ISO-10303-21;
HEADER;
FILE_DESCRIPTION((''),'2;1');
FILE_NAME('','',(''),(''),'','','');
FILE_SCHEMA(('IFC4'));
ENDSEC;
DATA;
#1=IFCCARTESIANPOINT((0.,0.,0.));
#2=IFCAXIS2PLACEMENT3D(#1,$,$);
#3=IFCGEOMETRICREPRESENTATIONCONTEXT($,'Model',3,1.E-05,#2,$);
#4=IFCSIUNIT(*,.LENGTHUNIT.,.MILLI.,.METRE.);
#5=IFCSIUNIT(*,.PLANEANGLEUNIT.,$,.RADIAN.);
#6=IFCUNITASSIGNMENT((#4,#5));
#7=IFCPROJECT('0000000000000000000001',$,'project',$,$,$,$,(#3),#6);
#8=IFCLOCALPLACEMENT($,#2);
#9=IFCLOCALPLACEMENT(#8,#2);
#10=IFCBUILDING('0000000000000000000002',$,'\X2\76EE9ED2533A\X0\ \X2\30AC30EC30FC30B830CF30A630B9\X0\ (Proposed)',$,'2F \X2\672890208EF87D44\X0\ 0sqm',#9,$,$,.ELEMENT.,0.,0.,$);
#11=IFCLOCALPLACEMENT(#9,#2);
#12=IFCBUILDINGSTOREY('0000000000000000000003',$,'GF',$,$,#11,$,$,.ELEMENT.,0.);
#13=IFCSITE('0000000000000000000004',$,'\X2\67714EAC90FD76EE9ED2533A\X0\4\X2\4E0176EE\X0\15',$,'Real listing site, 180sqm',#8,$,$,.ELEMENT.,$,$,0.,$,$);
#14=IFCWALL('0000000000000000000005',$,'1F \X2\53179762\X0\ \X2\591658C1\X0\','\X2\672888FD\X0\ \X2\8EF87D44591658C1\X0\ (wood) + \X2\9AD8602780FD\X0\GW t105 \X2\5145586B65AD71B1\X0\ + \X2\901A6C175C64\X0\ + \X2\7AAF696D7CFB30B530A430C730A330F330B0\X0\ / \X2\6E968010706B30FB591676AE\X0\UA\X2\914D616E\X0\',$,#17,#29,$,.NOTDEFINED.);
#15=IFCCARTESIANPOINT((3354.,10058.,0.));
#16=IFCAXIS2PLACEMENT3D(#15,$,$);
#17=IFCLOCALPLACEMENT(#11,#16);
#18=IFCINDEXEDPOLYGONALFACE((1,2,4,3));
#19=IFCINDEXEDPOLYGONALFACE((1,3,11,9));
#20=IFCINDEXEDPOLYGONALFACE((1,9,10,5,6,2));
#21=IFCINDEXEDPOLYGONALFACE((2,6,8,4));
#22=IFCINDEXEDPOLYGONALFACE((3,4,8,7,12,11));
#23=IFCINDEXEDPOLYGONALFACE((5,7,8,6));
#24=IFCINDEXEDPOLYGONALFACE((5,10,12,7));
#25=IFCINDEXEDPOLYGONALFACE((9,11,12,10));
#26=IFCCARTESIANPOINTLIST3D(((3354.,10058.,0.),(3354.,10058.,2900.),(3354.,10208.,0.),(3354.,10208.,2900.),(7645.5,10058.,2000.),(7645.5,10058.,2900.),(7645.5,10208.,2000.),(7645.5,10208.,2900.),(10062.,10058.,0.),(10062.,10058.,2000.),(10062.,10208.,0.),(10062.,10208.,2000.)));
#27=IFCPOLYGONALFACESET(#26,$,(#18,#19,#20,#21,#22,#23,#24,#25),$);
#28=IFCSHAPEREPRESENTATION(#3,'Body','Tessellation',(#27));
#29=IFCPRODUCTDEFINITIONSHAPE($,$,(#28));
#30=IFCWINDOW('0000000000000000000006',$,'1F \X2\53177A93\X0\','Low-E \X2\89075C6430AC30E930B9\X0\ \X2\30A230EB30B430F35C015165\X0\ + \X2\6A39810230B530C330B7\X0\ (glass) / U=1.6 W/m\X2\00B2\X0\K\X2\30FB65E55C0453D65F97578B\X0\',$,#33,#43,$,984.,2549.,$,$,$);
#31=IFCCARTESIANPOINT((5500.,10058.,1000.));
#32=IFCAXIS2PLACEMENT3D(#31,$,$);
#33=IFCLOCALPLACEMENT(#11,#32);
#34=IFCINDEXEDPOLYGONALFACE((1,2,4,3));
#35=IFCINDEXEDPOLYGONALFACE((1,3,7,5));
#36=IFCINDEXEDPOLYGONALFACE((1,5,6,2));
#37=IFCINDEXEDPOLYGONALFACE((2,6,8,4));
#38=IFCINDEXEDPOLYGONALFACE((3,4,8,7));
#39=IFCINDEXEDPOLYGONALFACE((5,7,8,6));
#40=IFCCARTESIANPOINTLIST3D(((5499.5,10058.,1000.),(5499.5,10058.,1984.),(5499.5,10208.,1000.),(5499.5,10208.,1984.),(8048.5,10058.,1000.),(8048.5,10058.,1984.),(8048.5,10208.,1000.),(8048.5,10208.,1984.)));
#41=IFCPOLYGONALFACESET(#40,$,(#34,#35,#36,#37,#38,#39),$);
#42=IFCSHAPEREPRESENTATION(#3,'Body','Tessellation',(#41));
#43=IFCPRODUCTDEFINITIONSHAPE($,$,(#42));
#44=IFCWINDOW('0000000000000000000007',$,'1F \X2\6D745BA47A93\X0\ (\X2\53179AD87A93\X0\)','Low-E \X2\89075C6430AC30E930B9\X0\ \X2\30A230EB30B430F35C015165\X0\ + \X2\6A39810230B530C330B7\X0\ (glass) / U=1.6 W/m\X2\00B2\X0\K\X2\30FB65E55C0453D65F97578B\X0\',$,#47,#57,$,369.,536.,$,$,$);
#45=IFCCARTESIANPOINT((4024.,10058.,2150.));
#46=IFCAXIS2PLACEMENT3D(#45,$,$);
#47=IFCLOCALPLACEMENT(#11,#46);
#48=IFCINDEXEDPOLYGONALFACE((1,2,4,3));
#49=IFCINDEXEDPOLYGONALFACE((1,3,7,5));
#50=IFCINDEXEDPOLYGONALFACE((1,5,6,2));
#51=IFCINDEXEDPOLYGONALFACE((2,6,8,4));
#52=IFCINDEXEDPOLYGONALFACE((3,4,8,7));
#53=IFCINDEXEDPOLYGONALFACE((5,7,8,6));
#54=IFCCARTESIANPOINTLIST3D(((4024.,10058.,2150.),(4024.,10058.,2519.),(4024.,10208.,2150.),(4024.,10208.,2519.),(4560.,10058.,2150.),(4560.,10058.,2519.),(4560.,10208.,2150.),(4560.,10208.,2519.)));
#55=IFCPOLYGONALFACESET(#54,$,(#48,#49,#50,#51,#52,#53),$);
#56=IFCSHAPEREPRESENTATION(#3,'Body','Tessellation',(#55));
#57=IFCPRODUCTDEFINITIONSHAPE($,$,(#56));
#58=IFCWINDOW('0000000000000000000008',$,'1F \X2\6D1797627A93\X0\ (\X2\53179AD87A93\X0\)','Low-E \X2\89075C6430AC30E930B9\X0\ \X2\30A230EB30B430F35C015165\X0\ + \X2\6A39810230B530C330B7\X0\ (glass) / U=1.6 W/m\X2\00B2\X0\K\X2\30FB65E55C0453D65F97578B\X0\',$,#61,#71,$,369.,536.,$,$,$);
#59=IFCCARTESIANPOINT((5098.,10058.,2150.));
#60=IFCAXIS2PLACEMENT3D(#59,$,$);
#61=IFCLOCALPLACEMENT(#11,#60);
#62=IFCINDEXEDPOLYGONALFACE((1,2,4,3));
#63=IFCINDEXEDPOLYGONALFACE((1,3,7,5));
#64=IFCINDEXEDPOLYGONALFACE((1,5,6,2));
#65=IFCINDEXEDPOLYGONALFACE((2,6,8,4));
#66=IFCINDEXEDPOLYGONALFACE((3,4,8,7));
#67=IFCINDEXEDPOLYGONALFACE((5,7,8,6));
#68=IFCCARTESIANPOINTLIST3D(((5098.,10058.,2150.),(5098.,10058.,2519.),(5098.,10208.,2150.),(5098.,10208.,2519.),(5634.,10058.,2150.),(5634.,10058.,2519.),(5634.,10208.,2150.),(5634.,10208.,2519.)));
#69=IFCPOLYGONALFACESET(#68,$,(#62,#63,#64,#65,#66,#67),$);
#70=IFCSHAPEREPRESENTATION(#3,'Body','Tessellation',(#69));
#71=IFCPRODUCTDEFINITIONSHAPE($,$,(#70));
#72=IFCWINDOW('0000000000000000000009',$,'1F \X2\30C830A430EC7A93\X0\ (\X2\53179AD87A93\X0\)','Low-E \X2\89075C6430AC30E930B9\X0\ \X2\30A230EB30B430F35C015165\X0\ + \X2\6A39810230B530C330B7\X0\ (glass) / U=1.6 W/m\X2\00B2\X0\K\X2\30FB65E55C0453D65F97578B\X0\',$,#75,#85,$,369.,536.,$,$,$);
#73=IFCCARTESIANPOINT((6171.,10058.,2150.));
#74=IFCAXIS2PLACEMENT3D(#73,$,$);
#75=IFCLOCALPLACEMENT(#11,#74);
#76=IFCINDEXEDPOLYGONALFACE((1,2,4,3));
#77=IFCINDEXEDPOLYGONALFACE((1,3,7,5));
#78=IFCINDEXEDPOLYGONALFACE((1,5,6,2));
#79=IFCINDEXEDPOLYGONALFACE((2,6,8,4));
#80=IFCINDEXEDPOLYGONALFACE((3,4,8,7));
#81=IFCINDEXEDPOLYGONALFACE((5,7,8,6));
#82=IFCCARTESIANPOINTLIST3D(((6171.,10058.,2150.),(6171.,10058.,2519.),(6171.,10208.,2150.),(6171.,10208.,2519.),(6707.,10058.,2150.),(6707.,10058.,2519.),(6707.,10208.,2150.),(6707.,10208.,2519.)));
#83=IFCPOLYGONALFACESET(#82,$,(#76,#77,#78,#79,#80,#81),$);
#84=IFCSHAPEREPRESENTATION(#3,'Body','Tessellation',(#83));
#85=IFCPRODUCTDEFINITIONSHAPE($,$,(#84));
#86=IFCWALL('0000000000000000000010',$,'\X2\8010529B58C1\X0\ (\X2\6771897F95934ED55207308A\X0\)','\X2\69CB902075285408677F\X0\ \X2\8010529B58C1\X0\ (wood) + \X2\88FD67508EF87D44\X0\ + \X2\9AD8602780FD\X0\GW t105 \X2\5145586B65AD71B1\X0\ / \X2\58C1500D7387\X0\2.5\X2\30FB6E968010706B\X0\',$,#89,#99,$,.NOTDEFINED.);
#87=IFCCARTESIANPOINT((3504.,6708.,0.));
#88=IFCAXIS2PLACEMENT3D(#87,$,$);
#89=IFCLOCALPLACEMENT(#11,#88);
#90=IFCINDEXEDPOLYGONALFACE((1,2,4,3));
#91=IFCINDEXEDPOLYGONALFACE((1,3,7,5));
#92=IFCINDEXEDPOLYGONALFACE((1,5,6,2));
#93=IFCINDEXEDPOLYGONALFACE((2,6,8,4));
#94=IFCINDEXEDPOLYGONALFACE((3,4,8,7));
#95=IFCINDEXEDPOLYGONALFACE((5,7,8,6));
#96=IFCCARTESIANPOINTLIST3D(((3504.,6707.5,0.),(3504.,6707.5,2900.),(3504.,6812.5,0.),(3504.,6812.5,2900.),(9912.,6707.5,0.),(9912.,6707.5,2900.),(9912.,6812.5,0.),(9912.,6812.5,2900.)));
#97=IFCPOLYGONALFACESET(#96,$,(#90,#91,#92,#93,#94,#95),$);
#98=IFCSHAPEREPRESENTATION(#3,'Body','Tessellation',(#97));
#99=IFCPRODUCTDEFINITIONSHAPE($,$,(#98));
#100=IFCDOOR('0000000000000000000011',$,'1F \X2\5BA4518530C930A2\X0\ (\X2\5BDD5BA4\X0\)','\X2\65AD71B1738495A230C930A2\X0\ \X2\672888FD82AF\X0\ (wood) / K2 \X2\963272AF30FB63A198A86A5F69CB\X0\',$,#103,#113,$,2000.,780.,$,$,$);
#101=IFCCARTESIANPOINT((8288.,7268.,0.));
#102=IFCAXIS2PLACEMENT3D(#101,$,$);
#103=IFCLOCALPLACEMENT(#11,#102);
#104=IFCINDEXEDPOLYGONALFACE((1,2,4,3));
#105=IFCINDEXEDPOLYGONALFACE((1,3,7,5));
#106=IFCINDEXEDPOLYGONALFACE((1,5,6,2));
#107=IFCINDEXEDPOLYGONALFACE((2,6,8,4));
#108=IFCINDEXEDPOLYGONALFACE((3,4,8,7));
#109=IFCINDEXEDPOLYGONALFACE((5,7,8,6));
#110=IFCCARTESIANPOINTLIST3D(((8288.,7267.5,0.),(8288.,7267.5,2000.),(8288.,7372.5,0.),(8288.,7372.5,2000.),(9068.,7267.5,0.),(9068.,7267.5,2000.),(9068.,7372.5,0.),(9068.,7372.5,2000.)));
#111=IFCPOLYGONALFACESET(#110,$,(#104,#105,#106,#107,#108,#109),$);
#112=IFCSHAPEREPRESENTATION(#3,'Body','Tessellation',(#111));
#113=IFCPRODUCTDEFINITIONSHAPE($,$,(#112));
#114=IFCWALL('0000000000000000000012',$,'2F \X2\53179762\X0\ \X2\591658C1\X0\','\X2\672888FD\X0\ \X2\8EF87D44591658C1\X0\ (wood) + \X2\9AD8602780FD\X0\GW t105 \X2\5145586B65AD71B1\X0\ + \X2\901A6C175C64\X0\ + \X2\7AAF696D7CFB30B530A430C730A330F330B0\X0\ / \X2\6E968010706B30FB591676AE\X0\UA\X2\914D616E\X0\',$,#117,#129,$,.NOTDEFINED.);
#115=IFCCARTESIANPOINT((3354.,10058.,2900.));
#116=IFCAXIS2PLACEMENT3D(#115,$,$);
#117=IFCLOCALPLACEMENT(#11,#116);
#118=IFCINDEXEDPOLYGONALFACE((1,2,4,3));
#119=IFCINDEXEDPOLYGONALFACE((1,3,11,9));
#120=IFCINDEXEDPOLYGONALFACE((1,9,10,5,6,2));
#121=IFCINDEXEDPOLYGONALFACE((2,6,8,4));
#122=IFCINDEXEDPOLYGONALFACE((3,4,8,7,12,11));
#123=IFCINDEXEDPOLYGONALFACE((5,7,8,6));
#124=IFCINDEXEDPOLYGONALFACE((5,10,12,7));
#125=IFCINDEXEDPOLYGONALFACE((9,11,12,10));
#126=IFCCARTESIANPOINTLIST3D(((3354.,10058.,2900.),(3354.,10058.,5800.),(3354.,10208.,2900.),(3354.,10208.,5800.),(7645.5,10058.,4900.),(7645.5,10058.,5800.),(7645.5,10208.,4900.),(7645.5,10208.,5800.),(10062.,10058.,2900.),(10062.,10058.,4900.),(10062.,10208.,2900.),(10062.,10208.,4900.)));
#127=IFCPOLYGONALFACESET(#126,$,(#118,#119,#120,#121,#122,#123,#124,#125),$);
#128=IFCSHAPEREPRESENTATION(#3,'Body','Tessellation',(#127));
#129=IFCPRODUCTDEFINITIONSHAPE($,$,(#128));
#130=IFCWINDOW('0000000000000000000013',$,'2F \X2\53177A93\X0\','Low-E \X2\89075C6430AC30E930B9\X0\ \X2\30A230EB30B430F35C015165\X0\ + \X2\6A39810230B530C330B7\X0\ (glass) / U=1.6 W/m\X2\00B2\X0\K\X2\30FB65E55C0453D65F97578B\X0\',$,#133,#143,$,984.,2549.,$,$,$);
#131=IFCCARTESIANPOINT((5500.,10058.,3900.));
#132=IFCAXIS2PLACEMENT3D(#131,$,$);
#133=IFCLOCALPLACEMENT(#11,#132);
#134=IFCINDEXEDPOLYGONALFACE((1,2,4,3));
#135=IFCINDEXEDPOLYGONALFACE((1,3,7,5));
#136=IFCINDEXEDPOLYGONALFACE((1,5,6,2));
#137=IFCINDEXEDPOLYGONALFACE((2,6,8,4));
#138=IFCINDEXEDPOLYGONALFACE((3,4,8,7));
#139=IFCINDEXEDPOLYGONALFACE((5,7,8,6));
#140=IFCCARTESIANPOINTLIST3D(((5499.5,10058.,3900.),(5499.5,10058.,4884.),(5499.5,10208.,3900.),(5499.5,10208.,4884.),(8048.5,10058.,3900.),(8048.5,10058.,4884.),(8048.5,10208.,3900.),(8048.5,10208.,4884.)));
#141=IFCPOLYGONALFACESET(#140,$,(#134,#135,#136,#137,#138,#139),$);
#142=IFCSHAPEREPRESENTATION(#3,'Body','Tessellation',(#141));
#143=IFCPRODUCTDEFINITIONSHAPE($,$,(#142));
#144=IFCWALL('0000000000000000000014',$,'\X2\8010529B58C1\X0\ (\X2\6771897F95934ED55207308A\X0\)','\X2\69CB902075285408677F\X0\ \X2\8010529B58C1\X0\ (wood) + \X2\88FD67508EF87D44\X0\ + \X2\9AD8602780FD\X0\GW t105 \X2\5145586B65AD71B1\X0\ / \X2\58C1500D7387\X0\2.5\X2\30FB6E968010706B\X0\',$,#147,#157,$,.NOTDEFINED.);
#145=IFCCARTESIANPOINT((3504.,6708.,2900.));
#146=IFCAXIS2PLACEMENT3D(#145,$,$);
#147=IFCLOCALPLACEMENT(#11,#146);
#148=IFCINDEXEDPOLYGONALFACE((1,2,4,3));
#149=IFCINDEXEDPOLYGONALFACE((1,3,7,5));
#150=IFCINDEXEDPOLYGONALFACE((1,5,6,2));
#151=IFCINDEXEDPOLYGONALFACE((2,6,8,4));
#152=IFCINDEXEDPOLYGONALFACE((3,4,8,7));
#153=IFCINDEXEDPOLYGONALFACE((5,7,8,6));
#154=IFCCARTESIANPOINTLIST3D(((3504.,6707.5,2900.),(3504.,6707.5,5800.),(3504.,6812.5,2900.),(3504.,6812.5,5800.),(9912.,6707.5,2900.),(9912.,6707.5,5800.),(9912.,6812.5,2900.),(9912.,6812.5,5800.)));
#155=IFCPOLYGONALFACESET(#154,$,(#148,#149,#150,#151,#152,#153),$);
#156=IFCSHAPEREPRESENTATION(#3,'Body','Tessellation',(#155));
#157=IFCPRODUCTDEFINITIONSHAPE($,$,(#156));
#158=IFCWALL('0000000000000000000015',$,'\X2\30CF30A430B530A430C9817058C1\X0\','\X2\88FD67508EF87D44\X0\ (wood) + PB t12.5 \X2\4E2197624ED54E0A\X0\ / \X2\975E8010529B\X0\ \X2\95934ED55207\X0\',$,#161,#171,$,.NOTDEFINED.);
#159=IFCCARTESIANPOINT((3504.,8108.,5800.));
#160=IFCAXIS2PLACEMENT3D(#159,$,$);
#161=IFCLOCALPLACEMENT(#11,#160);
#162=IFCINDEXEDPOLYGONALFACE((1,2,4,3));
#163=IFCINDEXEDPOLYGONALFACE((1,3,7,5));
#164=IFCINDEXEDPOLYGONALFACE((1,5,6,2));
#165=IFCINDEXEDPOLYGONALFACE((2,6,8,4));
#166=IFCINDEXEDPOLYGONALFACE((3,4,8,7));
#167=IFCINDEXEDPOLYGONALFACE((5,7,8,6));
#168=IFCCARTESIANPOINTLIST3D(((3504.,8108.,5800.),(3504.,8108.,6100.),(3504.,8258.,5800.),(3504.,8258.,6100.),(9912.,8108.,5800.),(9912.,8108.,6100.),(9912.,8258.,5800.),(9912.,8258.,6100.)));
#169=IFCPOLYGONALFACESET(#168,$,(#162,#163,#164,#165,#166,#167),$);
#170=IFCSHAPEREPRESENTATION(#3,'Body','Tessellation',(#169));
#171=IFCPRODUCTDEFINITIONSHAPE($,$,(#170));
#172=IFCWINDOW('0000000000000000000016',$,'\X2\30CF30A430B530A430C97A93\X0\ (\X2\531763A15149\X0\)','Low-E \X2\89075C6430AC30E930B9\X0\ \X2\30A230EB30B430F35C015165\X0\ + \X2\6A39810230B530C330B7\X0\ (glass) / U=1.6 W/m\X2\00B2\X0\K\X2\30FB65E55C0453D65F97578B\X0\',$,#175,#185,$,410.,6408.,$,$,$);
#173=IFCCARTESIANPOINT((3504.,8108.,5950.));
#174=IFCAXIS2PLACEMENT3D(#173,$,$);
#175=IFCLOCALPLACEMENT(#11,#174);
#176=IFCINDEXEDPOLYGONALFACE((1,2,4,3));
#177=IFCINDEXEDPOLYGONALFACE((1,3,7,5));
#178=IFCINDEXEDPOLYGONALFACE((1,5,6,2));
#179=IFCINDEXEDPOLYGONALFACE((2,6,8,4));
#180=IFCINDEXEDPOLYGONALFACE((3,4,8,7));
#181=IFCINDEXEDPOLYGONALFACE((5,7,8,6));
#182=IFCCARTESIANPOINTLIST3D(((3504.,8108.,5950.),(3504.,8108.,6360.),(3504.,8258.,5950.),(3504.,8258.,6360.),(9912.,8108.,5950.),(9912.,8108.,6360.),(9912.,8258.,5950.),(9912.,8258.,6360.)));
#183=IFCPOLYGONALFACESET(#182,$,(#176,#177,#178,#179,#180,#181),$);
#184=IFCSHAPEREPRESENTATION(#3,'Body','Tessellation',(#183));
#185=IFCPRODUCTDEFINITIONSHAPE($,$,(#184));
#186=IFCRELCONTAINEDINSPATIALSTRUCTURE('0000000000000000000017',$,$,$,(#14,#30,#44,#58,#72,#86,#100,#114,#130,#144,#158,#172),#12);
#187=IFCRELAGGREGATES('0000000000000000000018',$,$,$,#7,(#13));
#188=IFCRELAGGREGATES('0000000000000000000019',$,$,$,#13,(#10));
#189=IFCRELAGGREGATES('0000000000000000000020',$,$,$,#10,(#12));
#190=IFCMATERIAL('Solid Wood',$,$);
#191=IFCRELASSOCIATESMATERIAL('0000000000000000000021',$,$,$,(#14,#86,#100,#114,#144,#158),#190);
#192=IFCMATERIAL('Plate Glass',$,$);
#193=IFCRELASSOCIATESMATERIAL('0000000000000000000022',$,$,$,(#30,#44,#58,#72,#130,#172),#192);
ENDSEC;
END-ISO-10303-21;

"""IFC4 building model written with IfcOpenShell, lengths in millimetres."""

from ifc_helpers import new_model, si_unit, frame, frame_2d, origin, place, context, project, spatial, rectangle, extrude, material, element, fill, save


model = new_model("IFC4")

# Units and contexts
model_context = context("Model", 3, precision=1e-05, world=origin())
ifc_project = project(units=[si_unit("LENGTHUNIT", "METRE", prefix="MILLI"), si_unit("PLANEANGLEUNIT", "RADIAN")], contexts=[model_context])

# Site, building, storey
site_placement = place(None, origin())
site = spatial("IfcSite", under=ifc_project, at=site_placement, Name="東京都目黒区4丁目15", ObjectType="Real listing site, 180sqm", CompositionType="ELEMENT", RefElevation=0.0)
building_placement = place(site_placement, origin())
building = spatial("IfcBuilding", under=site, at=building_placement, Name="目黒区 ガレージハウス (Proposed)", ObjectType="2F 木造軸組 0sqm", CompositionType="ELEMENT", ElevationOfRefHeight=0.0, ElevationOfTerrain=0.0)
storey_placement = place(building_placement, origin())
storey = spatial("IfcBuildingStorey", under=building, at=storey_placement, Name="GF", CompositionType="ELEMENT", Elevation=0.0)

# Wall, openings, windows
ifc_material_1 = material(Name="Solid Wood")
wall_1_placement = place(storey_placement, frame((3354.0, 10058.0, 0.0)))
wall_1 = element("IfcWall", 1, at=wall_1_placement, inside=storey, material=ifc_material_1, Name="1F 北面 外壁", Description="木製 軸組外壁 (wood) + 高性能GW t105 充填断熱 + 通気層 + 窯業系サイディング / 準耐火・外皮UA配慮", PredefinedType="NOTDEFINED", context=model_context, shape_type="SweptSolid", body=[
    extrude(rectangle(XDim=6708.0, YDim=150.0, at=frame_2d((3354.0, 75.0))), frame((3354.0, 10058.0, 0.0)), (0.0, 0.0, 1.0), 2900.0),
])
opening_1_placement = place(storey_placement, frame((5500.0, 10058.0, 1000.0)))
opening_1 = element("IfcOpeningElement", 2, at=opening_1_placement, cuts=wall_1, PredefinedType="NOTDEFINED", context=model_context, shape_type="SweptSolid", body=[
    extrude(rectangle(XDim=2549.0, YDim=150.0, at=frame_2d((1274.0, 75.0))), frame((5500.0, 10058.0, 1000.0)), (0.0, 0.0, 1.0), 984.0),
])
opening_2_placement = place(storey_placement, frame((4024.0, 10058.0, 2150.0)))
opening_2 = element("IfcOpeningElement", 3, at=opening_2_placement, cuts=wall_1, PredefinedType="NOTDEFINED", context=model_context, shape_type="SweptSolid", body=[
    extrude(rectangle(XDim=536.0, YDim=150.0, at=frame_2d((268.0, 75.0))), frame((4024.0, 10058.0, 2150.0)), (0.0, 0.0, 1.0), 369.0),
])
opening_3_placement = place(storey_placement, frame((5098.0, 10058.0, 2150.0)))
opening_3 = element("IfcOpeningElement", 4, at=opening_3_placement, cuts=wall_1, PredefinedType="NOTDEFINED", context=model_context, shape_type="SweptSolid", body=[
    extrude(rectangle(XDim=536.0, YDim=150.0, at=frame_2d((268.0, 75.0))), frame((5098.0, 10058.0, 2150.0)), (0.0, 0.0, 1.0), 369.0),
])
opening_4_placement = place(storey_placement, frame((6171.0, 10058.0, 2150.0)))
opening_4 = element("IfcOpeningElement", 5, at=opening_4_placement, cuts=wall_1, PredefinedType="NOTDEFINED", context=model_context, shape_type="SweptSolid", body=[
    extrude(rectangle(XDim=536.0, YDim=150.0, at=frame_2d((268.0, 75.0))), frame((6171.0, 10058.0, 2150.0)), (0.0, 0.0, 1.0), 369.0),
])
ifc_material_2 = material(Name="Plate Glass")
window_1_placement = place(storey_placement, frame((5500.0, 10058.0, 1000.0)))
window_1 = element("IfcWindow", 6, at=window_1_placement, inside=storey, material=ifc_material_2, Name="1F 北窓", Description="Low-E 複層ガラス アルゴン封入 + 樹脂サッシ (glass) / U=1.6 W/m²K・日射取得型", OverallHeight=984.0, OverallWidth=2549.0, context=model_context, shape_type="SweptSolid", body=[
    extrude(rectangle(XDim=2549.0, YDim=150.0, at=frame_2d((1274.0, 75.0))), frame((5500.0, 10058.0, 1000.0)), (0.0, 0.0, 1.0), 984.0),
])
fill(opening_1, window_1)
window_2_placement = place(storey_placement, frame((4024.0, 10058.0, 2150.0)))
window_2 = element("IfcWindow", 7, at=window_2_placement, inside=storey, material=ifc_material_2, Name="1F 浴室窓 (北高窓)", Description="Low-E 複層ガラス アルゴン封入 + 樹脂サッシ (glass) / U=1.6 W/m²K・日射取得型", OverallHeight=369.0, OverallWidth=536.0, context=model_context, shape_type="SweptSolid", body=[
    extrude(rectangle(XDim=536.0, YDim=150.0, at=frame_2d((268.0, 75.0))), frame((4024.0, 10058.0, 2150.0)), (0.0, 0.0, 1.0), 369.0),
])
fill(opening_2, window_2)
window_3_placement = place(storey_placement, frame((5098.0, 10058.0, 2150.0)))
window_3 = element("IfcWindow", 8, at=window_3_placement, inside=storey, material=ifc_material_2, Name="1F 洗面窓 (北高窓)", Description="Low-E 複層ガラス アルゴン封入 + 樹脂サッシ (glass) / U=1.6 W/m²K・日射取得型", OverallHeight=369.0, OverallWidth=536.0, context=model_context, shape_type="SweptSolid", body=[
    extrude(rectangle(XDim=536.0, YDim=150.0, at=frame_2d((268.0, 75.0))), frame((5098.0, 10058.0, 2150.0)), (0.0, 0.0, 1.0), 369.0),
])
fill(opening_3, window_3)
window_4_placement = place(storey_placement, frame((6171.0, 10058.0, 2150.0)))
window_4 = element("IfcWindow", 9, at=window_4_placement, inside=storey, material=ifc_material_2, Name="1F トイレ窓 (北高窓)", Description="Low-E 複層ガラス アルゴン封入 + 樹脂サッシ (glass) / U=1.6 W/m²K・日射取得型", OverallHeight=369.0, OverallWidth=536.0, context=model_context, shape_type="SweptSolid", body=[
    extrude(rectangle(XDim=536.0, YDim=150.0, at=frame_2d((268.0, 75.0))), frame((6171.0, 10058.0, 2150.0)), (0.0, 0.0, 1.0), 369.0),
])
fill(opening_4, window_4)

# Wall
wall_2_placement = place(storey_placement, frame((3504.0, 6708.0, 0.0)))
element("IfcWall", 10, at=wall_2_placement, inside=storey, material=ifc_material_1, Name="耐力壁 (東西間仕切り)", Description="構造用合板 耐力壁 (wood) + 製材軸組 + 高性能GW t105 充填断熱 / 壁倍率2.5・準耐火", PredefinedType="NOTDEFINED", context=model_context, shape_type="SweptSolid", body=[
    extrude(rectangle(XDim=6408.0, YDim=105.0, at=frame_2d((3204.0, 52.0))), frame((3504.0, 6708.0, 0.0)), (0.0, 0.0, 1.0), 2900.0),
])

# Door
door_1_placement = place(storey_placement, frame((8288.0, 7268.0, 0.0)))
element("IfcDoor", 11, at=door_1_placement, inside=storey, material=ifc_material_1, Name="1F 室内ドア (寝室)", Description="断熱玄関ドア 木製芯 (wood) / K2 防犯・採風機構", OverallHeight=2000.0, OverallWidth=780.0, context=model_context, shape_type="SweptSolid", body=[
    extrude(rectangle(XDim=780.0, YDim=105.0, at=frame_2d((390.0, 52.0))), frame((8288.0, 7268.0, 0.0)), (0.0, 0.0, 1.0), 2000.0),
])

# Wall, opening, window
wall_3_placement = place(storey_placement, frame((3354.0, 10058.0, 2900.0)))
wall_3 = element("IfcWall", 12, at=wall_3_placement, inside=storey, material=ifc_material_1, Name="2F 北面 外壁", Description="木製 軸組外壁 (wood) + 高性能GW t105 充填断熱 + 通気層 + 窯業系サイディング / 準耐火・外皮UA配慮", PredefinedType="NOTDEFINED", context=model_context, shape_type="SweptSolid", body=[
    extrude(rectangle(XDim=6708.0, YDim=150.0, at=frame_2d((3354.0, 75.0))), frame((3354.0, 10058.0, 2900.0)), (0.0, 0.0, 1.0), 2900.0),
])
opening_5_placement = place(storey_placement, frame((5500.0, 10058.0, 3900.0)))
opening_5 = element("IfcOpeningElement", 13, at=opening_5_placement, cuts=wall_3, PredefinedType="NOTDEFINED", context=model_context, shape_type="SweptSolid", body=[
    extrude(rectangle(XDim=2549.0, YDim=150.0, at=frame_2d((1274.0, 75.0))), frame((5500.0, 10058.0, 3900.0)), (0.0, 0.0, 1.0), 984.0),
])
window_5_placement = place(storey_placement, frame((5500.0, 10058.0, 3900.0)))
window_5 = element("IfcWindow", 14, at=window_5_placement, inside=storey, material=ifc_material_2, Name="2F 北窓", Description="Low-E 複層ガラス アルゴン封入 + 樹脂サッシ (glass) / U=1.6 W/m²K・日射取得型", OverallHeight=984.0, OverallWidth=2549.0, context=model_context, shape_type="SweptSolid", body=[
    extrude(rectangle(XDim=2549.0, YDim=150.0, at=frame_2d((1274.0, 75.0))), frame((5500.0, 10058.0, 3900.0)), (0.0, 0.0, 1.0), 984.0),
])
fill(opening_5, window_5)

# Wall
wall_4_placement = place(storey_placement, frame((3504.0, 6708.0, 2900.0)))
element("IfcWall", 15, at=wall_4_placement, inside=storey, material=ifc_material_1, Name="耐力壁 (東西間仕切り)", Description="構造用合板 耐力壁 (wood) + 製材軸組 + 高性能GW t105 充填断熱 / 壁倍率2.5・準耐火", PredefinedType="NOTDEFINED", context=model_context, shape_type="SweptSolid", body=[
    extrude(rectangle(XDim=6408.0, YDim=105.0, at=frame_2d((3204.0, 52.0))), frame((3504.0, 6708.0, 2900.0)), (0.0, 0.0, 1.0), 2900.0),
])

# Wall, opening, window
wall_5_placement = place(storey_placement, frame((3504.0, 8108.0, 5800.0)))
wall_5 = element("IfcWall", 16, at=wall_5_placement, inside=storey, material=ifc_material_1, Name="ハイサイド腰壁", Description="製材軸組 (wood) + PB t12.5 両面仕上 / 非耐力 間仕切", PredefinedType="NOTDEFINED", context=model_context, shape_type="SweptSolid", body=[
    extrude(rectangle(XDim=6408.0, YDim=150.0, at=frame_2d((3204.0, 75.0))), frame((3504.0, 8108.0, 5800.0)), (0.0, 0.0, 1.0), 700.0),
])
opening_6_placement = place(storey_placement, frame((3504.0, 8108.0, 5950.0)))
opening_6 = element("IfcOpeningElement", 17, at=opening_6_placement, cuts=wall_5, PredefinedType="NOTDEFINED", context=model_context, shape_type="SweptSolid", body=[
    extrude(rectangle(XDim=6408.0, YDim=150.0, at=frame_2d((3204.0, 75.0))), frame((3504.0, 8108.0, 5950.0)), (0.0, 0.0, 1.0), 410.0),
])
window_6_placement = place(storey_placement, frame((3504.0, 8108.0, 5950.0)))
window_6 = element("IfcWindow", 18, at=window_6_placement, inside=storey, material=ifc_material_2, Name="ハイサイド窓 (北採光)", Description="Low-E 複層ガラス アルゴン封入 + 樹脂サッシ (glass) / U=1.6 W/m²K・日射取得型", OverallHeight=410.0, OverallWidth=6408.0, context=model_context, shape_type="SweptSolid", body=[
    extrude(rectangle(XDim=6408.0, YDim=150.0, at=frame_2d((3204.0, 75.0))), frame((3504.0, 8108.0, 5950.0)), (0.0, 0.0, 1.0), 410.0),
])
fill(opening_6, window_6)

save(model, "model.ifc")
